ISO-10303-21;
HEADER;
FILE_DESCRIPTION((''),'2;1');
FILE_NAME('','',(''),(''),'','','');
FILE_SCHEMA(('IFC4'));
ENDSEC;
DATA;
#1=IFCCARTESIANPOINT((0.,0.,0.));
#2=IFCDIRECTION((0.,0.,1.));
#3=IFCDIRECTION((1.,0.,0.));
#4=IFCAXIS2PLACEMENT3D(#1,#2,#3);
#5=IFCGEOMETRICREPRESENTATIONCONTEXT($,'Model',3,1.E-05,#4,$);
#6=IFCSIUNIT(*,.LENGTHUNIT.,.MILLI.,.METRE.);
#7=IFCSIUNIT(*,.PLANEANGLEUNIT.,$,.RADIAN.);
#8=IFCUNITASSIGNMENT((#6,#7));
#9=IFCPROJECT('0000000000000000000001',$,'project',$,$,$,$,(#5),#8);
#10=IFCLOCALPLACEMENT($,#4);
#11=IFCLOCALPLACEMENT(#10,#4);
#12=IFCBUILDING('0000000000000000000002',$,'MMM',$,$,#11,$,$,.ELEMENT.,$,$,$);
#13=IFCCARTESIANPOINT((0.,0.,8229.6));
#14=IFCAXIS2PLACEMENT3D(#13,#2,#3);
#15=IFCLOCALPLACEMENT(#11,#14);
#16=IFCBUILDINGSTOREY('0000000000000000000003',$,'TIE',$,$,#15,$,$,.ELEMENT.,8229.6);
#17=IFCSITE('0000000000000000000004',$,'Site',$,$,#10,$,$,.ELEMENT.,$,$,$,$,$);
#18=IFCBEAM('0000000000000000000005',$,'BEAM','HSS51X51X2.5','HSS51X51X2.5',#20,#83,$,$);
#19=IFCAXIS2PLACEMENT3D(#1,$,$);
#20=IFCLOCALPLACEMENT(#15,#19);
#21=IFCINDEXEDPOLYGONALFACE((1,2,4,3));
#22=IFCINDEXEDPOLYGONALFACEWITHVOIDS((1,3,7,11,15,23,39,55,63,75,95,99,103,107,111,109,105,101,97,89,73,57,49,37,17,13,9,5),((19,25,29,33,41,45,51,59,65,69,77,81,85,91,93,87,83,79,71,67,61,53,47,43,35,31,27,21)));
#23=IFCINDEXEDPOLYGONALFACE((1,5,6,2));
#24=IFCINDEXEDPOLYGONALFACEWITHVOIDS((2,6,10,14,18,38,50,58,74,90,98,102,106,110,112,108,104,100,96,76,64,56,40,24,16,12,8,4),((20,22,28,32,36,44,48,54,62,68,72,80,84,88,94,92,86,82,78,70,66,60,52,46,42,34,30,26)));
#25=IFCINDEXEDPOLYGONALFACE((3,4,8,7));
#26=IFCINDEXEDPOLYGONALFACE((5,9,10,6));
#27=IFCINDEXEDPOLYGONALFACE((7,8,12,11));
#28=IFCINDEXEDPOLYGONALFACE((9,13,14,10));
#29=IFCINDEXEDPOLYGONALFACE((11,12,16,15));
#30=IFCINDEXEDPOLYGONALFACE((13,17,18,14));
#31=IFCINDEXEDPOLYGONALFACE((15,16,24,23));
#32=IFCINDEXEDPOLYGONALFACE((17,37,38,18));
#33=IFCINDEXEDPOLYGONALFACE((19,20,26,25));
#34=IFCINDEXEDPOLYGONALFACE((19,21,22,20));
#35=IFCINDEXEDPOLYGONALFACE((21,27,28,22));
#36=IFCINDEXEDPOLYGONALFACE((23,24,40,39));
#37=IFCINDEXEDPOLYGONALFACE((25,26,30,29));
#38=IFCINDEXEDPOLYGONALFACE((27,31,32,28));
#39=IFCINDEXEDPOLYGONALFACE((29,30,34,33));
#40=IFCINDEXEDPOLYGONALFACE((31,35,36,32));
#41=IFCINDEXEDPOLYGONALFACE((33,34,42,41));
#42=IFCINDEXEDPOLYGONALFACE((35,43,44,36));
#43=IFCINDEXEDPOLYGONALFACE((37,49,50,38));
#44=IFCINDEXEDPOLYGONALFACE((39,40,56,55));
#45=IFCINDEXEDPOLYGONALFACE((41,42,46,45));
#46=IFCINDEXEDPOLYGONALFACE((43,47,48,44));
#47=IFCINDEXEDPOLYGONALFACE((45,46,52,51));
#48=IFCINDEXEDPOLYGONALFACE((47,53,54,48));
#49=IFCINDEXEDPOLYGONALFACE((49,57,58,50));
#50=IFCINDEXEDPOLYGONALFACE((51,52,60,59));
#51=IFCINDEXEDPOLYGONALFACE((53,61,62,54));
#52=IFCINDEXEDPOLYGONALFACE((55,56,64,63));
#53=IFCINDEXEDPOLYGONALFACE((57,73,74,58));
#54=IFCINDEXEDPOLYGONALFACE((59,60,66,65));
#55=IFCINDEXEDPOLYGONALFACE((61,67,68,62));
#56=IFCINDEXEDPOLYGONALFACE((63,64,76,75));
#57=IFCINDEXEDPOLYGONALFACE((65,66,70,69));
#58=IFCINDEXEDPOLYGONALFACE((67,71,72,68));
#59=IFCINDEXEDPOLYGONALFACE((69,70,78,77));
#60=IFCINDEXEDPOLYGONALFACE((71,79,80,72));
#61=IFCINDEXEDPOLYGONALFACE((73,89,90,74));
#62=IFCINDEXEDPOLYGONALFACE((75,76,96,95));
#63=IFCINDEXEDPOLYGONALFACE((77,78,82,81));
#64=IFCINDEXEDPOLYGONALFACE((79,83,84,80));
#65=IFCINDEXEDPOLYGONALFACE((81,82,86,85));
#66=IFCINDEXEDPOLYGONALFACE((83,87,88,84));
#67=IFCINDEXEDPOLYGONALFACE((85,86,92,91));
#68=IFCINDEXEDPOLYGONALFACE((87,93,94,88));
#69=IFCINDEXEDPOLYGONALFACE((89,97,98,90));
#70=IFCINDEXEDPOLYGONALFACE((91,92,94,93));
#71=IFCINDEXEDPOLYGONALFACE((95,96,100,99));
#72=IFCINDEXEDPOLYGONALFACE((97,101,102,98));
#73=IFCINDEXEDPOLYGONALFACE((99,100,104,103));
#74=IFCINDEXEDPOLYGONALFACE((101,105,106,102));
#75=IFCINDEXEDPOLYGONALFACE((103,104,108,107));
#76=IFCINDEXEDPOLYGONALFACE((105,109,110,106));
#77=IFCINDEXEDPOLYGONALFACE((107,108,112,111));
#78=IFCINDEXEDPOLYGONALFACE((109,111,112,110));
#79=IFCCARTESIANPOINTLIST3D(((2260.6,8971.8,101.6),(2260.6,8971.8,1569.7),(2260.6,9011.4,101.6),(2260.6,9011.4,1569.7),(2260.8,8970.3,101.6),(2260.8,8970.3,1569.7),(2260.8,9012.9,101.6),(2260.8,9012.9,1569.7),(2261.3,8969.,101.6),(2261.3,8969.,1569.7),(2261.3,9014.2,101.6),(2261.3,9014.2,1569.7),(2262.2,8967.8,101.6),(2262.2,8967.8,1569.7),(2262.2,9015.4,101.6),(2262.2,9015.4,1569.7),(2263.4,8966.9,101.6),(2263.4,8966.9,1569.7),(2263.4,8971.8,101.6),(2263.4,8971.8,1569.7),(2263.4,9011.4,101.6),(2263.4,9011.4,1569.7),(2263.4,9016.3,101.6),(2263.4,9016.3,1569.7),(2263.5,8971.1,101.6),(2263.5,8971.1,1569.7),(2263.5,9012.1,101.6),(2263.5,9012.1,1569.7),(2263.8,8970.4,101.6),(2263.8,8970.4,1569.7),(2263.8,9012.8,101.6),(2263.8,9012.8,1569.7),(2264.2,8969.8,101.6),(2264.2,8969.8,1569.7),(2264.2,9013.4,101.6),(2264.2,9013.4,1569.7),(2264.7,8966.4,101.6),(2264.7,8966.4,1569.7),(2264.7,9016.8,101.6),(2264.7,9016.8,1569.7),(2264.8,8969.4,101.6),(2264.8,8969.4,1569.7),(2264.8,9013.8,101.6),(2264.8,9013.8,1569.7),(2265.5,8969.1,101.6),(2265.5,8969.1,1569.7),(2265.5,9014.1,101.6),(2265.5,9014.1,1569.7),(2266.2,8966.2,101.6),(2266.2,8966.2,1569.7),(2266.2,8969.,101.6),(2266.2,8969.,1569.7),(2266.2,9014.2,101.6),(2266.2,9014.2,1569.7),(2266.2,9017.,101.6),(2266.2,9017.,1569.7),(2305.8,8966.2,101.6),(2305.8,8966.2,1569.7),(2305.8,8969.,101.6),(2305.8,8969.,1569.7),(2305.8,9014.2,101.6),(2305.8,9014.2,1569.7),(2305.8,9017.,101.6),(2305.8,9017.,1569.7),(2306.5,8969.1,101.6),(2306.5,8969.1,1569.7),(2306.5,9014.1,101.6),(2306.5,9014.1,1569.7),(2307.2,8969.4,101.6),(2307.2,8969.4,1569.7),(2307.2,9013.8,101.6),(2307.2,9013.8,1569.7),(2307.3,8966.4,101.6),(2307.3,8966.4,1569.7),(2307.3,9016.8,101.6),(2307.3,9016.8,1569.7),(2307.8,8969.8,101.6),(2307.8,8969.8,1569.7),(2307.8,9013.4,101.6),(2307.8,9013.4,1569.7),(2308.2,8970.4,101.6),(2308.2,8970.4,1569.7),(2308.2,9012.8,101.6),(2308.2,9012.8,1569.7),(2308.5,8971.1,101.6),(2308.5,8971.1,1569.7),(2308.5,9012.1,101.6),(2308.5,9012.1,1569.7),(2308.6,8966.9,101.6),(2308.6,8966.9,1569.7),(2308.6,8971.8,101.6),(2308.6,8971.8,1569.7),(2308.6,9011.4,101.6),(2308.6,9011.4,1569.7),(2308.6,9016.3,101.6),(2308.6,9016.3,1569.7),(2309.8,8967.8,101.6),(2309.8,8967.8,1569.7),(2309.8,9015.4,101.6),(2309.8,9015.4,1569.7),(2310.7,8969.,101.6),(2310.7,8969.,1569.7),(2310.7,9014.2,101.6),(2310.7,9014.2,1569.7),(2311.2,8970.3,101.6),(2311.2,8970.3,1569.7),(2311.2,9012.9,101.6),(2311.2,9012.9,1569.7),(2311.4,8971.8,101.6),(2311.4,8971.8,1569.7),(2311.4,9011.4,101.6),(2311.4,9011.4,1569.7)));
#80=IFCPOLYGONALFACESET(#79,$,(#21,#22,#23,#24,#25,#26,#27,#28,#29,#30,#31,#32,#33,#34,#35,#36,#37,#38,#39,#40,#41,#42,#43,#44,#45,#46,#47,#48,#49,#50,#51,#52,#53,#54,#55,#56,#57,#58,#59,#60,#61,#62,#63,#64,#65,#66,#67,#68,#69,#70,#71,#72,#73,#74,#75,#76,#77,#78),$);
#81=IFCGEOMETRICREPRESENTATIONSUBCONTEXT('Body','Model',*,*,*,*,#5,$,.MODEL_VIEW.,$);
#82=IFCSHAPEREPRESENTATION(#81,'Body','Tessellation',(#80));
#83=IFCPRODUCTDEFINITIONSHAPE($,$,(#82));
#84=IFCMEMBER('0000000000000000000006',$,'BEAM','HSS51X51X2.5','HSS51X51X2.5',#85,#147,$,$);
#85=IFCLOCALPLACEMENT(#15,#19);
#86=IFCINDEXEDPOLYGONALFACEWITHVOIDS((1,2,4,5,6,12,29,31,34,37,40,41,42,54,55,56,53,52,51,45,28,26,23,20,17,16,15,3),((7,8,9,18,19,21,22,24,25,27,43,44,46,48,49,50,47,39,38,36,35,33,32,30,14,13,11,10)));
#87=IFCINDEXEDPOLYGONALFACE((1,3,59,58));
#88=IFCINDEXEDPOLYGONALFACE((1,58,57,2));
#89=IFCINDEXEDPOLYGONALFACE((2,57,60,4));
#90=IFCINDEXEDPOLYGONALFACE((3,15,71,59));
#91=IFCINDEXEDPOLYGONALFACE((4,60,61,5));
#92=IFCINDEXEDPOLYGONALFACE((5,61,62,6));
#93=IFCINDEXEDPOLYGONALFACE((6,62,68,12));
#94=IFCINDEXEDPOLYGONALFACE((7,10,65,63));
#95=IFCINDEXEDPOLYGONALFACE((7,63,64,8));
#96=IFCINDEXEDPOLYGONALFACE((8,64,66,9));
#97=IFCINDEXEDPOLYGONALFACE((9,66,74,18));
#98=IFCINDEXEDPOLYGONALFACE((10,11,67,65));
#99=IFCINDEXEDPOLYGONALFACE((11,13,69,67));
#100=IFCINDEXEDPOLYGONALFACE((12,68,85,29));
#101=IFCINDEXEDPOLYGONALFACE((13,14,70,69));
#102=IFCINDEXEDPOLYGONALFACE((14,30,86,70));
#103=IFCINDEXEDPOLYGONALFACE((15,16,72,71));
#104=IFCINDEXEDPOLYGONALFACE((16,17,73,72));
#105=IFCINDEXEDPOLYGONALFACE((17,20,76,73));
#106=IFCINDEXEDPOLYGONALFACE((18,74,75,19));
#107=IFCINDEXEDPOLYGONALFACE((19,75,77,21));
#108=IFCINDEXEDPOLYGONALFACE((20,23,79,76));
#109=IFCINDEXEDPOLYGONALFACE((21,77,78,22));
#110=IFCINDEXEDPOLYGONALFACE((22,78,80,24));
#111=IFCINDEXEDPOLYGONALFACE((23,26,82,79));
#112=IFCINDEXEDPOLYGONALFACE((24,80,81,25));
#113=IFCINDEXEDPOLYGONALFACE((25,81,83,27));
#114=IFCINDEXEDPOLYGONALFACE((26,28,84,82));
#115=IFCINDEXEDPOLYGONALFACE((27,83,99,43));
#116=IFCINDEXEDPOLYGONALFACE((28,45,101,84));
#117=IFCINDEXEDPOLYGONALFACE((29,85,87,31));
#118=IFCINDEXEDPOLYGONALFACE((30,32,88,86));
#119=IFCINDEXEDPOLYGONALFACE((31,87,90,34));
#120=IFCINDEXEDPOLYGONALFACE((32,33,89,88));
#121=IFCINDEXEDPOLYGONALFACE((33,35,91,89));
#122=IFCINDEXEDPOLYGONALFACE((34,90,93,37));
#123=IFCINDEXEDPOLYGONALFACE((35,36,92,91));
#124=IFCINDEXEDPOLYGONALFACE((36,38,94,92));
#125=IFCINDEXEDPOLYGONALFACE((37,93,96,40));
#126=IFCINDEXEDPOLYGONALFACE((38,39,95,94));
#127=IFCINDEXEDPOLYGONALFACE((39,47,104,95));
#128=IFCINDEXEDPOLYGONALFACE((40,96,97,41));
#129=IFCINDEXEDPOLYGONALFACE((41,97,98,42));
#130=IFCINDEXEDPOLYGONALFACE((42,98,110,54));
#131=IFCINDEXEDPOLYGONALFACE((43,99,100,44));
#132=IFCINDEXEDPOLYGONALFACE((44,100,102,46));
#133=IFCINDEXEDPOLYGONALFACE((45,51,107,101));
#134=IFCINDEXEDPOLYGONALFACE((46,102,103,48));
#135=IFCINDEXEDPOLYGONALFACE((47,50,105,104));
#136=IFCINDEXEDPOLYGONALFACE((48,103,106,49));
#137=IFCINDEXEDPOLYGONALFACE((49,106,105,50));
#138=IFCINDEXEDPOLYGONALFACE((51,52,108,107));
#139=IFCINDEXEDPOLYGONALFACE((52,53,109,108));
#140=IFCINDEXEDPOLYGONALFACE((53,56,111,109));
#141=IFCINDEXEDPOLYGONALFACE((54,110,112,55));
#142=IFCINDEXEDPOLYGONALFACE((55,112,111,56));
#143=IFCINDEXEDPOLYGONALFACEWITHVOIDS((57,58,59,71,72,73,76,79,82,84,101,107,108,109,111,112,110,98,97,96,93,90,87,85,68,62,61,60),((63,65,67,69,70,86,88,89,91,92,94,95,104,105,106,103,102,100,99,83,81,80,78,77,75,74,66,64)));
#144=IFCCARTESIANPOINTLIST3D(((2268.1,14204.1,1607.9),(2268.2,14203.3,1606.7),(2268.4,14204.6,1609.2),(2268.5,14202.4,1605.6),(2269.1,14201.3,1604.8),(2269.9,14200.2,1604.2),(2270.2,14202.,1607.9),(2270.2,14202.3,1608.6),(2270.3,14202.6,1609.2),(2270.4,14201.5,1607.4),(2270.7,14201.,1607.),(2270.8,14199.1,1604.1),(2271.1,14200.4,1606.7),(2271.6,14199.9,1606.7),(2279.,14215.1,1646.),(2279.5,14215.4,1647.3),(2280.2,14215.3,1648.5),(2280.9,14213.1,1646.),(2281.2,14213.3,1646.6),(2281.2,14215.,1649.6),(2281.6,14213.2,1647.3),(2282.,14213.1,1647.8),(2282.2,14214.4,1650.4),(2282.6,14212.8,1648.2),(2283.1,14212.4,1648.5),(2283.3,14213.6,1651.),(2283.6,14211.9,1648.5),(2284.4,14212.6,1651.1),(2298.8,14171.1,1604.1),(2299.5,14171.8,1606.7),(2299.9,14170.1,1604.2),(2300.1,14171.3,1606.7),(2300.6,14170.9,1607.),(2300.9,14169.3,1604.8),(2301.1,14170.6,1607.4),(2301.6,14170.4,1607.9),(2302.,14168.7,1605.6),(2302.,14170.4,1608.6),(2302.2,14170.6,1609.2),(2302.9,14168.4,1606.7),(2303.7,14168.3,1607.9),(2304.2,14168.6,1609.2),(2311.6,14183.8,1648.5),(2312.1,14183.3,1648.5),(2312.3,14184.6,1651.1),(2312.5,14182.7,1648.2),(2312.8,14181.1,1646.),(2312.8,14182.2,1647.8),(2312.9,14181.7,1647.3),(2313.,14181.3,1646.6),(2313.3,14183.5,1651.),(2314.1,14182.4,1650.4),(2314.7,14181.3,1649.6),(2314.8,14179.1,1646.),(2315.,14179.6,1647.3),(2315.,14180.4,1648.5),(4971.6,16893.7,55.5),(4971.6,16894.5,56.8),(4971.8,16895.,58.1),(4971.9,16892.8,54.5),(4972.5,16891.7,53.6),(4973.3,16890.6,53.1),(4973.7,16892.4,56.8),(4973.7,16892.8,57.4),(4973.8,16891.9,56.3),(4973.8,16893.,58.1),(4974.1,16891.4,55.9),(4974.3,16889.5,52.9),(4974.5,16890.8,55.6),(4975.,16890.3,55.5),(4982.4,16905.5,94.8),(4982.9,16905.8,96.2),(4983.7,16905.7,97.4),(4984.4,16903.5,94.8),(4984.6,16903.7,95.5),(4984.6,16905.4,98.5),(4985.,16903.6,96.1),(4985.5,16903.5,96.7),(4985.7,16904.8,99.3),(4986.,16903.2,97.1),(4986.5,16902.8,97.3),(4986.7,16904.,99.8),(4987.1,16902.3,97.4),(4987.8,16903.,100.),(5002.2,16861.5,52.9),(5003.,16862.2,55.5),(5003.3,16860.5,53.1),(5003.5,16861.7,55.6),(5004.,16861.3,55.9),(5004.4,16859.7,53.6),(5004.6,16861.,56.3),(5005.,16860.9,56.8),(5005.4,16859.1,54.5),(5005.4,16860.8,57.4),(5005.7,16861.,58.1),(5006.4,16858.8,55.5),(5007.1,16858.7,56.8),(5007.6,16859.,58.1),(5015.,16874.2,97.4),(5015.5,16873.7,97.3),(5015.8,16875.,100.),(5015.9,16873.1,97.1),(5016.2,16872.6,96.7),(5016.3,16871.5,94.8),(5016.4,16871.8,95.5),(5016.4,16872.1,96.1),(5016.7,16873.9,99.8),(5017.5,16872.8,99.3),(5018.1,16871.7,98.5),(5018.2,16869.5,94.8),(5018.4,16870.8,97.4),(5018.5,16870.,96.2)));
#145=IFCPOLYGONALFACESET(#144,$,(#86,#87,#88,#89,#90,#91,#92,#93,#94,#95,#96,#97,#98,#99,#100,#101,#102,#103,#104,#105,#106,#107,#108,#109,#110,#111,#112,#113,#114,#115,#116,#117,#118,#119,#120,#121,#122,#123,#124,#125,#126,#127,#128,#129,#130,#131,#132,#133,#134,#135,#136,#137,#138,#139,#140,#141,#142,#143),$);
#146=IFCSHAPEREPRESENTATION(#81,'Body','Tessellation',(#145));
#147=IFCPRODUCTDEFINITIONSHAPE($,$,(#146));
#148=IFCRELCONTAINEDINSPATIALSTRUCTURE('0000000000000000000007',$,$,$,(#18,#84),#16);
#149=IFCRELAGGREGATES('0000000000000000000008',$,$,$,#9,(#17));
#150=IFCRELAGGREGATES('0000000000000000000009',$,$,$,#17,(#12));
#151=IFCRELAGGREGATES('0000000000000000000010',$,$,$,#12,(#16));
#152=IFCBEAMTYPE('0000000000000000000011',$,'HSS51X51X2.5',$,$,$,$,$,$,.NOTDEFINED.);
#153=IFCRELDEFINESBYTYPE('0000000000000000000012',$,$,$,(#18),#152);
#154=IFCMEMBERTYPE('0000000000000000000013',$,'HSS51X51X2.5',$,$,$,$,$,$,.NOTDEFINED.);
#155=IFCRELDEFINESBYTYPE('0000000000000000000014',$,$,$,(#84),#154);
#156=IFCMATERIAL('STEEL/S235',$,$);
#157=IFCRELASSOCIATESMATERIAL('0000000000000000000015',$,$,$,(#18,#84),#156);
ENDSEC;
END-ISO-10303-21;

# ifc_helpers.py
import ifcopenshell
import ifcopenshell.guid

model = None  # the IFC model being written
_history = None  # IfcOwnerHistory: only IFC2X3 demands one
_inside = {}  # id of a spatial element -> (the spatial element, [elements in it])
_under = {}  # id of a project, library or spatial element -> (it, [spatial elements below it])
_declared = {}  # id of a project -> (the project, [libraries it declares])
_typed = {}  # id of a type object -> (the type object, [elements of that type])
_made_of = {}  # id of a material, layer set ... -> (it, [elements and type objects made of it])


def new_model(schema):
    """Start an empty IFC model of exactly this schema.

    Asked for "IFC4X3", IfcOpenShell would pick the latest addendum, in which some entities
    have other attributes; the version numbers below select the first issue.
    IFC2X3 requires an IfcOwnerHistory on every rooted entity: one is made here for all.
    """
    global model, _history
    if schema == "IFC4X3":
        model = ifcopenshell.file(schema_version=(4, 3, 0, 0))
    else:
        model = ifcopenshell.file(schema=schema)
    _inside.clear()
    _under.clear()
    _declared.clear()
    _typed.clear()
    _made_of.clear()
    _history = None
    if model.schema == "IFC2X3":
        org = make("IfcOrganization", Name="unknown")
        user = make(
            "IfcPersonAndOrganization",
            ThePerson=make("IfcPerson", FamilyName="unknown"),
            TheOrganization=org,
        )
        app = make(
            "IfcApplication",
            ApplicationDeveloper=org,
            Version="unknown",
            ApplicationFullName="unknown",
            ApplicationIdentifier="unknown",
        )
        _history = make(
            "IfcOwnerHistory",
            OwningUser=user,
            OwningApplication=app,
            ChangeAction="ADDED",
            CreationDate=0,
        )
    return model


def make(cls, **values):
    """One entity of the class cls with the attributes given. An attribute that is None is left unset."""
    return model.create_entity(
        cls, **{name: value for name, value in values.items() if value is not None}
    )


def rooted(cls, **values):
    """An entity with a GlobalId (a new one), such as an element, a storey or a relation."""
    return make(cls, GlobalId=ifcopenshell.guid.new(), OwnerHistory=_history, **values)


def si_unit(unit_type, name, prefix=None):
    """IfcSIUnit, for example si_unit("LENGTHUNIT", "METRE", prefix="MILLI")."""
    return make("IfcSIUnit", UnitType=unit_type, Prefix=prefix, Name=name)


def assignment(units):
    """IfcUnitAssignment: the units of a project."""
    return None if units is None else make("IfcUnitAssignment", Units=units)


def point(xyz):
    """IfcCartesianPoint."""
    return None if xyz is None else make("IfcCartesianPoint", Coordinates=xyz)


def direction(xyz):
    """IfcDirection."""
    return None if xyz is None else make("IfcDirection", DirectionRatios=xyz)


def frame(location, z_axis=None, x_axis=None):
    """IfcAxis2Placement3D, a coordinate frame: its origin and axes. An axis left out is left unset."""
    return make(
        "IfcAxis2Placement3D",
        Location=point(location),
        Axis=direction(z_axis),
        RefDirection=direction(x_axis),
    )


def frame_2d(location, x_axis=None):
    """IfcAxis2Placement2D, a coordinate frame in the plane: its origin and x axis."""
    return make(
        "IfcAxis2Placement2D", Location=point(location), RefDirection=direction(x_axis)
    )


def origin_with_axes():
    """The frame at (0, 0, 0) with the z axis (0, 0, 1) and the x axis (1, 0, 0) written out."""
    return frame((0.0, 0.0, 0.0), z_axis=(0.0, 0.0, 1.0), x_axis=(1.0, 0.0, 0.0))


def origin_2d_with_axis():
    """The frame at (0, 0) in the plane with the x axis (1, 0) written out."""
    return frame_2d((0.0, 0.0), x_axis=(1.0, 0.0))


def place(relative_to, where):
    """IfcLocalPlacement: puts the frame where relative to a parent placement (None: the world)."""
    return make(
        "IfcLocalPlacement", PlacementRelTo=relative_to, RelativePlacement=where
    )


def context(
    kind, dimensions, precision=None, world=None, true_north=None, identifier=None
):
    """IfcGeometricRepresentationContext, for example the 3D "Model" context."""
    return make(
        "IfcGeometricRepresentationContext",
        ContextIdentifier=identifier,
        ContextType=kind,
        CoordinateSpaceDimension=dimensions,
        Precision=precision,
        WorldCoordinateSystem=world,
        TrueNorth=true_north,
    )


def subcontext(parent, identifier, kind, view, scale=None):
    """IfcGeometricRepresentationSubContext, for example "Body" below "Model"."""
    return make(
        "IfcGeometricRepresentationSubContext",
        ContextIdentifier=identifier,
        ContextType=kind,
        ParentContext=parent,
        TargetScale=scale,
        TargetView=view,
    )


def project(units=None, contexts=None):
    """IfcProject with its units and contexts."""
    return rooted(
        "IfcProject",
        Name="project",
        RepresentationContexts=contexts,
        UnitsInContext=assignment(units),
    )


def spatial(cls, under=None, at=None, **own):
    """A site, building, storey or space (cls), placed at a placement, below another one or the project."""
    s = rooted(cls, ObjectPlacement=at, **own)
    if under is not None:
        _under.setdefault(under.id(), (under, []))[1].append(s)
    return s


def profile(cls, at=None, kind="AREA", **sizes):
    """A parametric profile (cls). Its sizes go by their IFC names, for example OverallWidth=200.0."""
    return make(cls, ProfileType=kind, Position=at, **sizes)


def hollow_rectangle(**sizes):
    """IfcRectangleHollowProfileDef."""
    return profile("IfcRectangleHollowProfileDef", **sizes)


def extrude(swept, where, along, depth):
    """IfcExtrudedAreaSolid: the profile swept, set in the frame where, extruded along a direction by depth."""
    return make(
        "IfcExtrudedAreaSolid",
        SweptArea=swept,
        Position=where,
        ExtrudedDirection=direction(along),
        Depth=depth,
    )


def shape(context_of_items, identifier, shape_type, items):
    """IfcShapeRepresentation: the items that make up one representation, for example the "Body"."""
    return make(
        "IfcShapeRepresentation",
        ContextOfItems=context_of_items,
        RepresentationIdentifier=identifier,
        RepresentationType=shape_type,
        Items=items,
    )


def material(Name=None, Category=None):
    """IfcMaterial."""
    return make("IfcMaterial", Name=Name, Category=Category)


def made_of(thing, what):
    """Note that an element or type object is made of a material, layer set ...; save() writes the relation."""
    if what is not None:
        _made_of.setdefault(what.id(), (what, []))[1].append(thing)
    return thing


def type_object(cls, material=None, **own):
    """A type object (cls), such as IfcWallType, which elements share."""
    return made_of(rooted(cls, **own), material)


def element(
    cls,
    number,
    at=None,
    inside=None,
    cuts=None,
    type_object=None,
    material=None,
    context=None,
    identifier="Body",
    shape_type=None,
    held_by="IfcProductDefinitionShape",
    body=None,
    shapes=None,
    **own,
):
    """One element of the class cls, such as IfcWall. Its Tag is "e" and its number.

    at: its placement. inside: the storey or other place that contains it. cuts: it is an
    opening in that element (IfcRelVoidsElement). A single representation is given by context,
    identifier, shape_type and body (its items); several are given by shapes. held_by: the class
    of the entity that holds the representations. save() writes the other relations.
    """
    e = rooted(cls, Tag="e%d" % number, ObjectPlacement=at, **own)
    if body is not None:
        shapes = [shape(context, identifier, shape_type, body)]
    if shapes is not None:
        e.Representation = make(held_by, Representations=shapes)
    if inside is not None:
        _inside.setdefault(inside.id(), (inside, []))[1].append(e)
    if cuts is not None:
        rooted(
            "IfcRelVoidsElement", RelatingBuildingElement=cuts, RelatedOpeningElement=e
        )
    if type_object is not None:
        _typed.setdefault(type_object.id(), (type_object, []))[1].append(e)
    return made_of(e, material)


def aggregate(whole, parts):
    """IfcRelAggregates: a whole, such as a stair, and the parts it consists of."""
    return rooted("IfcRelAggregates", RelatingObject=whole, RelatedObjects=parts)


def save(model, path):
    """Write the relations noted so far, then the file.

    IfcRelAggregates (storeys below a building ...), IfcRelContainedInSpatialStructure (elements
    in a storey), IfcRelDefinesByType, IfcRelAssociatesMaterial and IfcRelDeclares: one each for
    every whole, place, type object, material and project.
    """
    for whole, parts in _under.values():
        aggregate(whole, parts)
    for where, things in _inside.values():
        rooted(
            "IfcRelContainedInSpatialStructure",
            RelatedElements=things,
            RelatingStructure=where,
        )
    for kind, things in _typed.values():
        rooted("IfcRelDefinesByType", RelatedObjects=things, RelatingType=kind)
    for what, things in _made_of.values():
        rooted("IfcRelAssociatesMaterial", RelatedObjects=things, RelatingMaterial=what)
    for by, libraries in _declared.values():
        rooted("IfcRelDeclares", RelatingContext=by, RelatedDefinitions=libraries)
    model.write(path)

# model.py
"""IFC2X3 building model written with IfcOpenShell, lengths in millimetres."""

from ifc_helpers import new_model, si_unit, frame, origin_with_axes, origin_2d_with_axis, place, context, subcontext, project, spatial, hollow_rectangle, extrude, material, type_object, element, save


model = new_model("IFC2X3")

# Units and contexts
model_context = context("Model", 3, precision=1e-05, world=origin_with_axes())
body_context = subcontext(model_context, "Body", "Model", "MODEL_VIEW")
ifc_project = project(units=[si_unit("LENGTHUNIT", "METRE", prefix="MILLI"), si_unit("PLANEANGLEUNIT", "RADIAN")], contexts=[model_context])

# Site, building, storey
site_placement = place(None, origin_with_axes())
site = spatial("IfcSite", under=ifc_project, at=site_placement, Name="Site", CompositionType="ELEMENT")
building_placement = place(site_placement, origin_with_axes())
building = spatial("IfcBuilding", under=site, at=building_placement, Name="MMM", CompositionType="ELEMENT")
storey_placement = place(building_placement, frame((0.0, 0.0, 8229.6), z_axis=(0.0, 0.0, 1.0), x_axis=(1.0, 0.0, 0.0)))
storey = spatial("IfcBuildingStorey", under=building, at=storey_placement, Name="TIE", CompositionType="ELEMENT", Elevation=8229.6)

# Beam
ifc_material = material(Name="STEEL/S235")
beam_type_1 = type_object("IfcBeamType", Name="HSS51X51X2.5", PredefinedType="NOTDEFINED")
beam_1_placement = place(storey_placement, frame((2286.0, 8991.6, 1569.7), z_axis=(1.0, 0.0, 0.0), x_axis=(0.0, 0.0, -1.0)))
element("IfcBeam", 1, at=beam_1_placement, inside=storey, type_object=beam_type_1, material=ifc_material, Name="BEAM", Description="HSS51X51X2.5", ObjectType="HSS51X51X2.5", context=body_context, shape_type="SweptSolid", body=[
    extrude(hollow_rectangle(XDim=50.8, YDim=50.8, WallThickness=2.8, InnerFilletRadius=2.8, OuterFilletRadius=5.6, at=origin_2d_with_axis()), frame((1468.1, 0.0, 0.0), z_axis=(-1.0, 0.0, 0.0), x_axis=(0.0, -1.0, 0.0)), (0.0, 0.0, 1.0), 1468.1),
])

# Member
member_type_1 = type_object("IfcMemberType", Name="HSS51X51X2.5", PredefinedType="NOTDEFINED")
member_1_placement = place(storey_placement, frame((2291.6, 14191.9, 1627.6), z_axis=(0.267029, 0.265742, 0.926324), x_axis=(0.656591, 0.653426, -0.376727)))
element("IfcMember", 2, at=member_1_placement, inside=storey, type_object=member_type_1, material=ifc_material, Name="BEAM", Description="HSS51X51X2.5", ObjectType="HSS51X51X2.5", context=body_context, shape_type="SweptSolid", body=[
    extrude(hollow_rectangle(XDim=50.8, YDim=50.8, WallThickness=2.8, InnerFilletRadius=2.8, OuterFilletRadius=5.6, at=origin_2d_with_axis()), frame((4117.4, 0.0, 0.0), z_axis=(-1.0, 0.0, 0.0), x_axis=(0.0, -1.0, 0.0)), (0.0, 0.0, 1.0), 4117.4),
])

save(model, "model.ifc")
